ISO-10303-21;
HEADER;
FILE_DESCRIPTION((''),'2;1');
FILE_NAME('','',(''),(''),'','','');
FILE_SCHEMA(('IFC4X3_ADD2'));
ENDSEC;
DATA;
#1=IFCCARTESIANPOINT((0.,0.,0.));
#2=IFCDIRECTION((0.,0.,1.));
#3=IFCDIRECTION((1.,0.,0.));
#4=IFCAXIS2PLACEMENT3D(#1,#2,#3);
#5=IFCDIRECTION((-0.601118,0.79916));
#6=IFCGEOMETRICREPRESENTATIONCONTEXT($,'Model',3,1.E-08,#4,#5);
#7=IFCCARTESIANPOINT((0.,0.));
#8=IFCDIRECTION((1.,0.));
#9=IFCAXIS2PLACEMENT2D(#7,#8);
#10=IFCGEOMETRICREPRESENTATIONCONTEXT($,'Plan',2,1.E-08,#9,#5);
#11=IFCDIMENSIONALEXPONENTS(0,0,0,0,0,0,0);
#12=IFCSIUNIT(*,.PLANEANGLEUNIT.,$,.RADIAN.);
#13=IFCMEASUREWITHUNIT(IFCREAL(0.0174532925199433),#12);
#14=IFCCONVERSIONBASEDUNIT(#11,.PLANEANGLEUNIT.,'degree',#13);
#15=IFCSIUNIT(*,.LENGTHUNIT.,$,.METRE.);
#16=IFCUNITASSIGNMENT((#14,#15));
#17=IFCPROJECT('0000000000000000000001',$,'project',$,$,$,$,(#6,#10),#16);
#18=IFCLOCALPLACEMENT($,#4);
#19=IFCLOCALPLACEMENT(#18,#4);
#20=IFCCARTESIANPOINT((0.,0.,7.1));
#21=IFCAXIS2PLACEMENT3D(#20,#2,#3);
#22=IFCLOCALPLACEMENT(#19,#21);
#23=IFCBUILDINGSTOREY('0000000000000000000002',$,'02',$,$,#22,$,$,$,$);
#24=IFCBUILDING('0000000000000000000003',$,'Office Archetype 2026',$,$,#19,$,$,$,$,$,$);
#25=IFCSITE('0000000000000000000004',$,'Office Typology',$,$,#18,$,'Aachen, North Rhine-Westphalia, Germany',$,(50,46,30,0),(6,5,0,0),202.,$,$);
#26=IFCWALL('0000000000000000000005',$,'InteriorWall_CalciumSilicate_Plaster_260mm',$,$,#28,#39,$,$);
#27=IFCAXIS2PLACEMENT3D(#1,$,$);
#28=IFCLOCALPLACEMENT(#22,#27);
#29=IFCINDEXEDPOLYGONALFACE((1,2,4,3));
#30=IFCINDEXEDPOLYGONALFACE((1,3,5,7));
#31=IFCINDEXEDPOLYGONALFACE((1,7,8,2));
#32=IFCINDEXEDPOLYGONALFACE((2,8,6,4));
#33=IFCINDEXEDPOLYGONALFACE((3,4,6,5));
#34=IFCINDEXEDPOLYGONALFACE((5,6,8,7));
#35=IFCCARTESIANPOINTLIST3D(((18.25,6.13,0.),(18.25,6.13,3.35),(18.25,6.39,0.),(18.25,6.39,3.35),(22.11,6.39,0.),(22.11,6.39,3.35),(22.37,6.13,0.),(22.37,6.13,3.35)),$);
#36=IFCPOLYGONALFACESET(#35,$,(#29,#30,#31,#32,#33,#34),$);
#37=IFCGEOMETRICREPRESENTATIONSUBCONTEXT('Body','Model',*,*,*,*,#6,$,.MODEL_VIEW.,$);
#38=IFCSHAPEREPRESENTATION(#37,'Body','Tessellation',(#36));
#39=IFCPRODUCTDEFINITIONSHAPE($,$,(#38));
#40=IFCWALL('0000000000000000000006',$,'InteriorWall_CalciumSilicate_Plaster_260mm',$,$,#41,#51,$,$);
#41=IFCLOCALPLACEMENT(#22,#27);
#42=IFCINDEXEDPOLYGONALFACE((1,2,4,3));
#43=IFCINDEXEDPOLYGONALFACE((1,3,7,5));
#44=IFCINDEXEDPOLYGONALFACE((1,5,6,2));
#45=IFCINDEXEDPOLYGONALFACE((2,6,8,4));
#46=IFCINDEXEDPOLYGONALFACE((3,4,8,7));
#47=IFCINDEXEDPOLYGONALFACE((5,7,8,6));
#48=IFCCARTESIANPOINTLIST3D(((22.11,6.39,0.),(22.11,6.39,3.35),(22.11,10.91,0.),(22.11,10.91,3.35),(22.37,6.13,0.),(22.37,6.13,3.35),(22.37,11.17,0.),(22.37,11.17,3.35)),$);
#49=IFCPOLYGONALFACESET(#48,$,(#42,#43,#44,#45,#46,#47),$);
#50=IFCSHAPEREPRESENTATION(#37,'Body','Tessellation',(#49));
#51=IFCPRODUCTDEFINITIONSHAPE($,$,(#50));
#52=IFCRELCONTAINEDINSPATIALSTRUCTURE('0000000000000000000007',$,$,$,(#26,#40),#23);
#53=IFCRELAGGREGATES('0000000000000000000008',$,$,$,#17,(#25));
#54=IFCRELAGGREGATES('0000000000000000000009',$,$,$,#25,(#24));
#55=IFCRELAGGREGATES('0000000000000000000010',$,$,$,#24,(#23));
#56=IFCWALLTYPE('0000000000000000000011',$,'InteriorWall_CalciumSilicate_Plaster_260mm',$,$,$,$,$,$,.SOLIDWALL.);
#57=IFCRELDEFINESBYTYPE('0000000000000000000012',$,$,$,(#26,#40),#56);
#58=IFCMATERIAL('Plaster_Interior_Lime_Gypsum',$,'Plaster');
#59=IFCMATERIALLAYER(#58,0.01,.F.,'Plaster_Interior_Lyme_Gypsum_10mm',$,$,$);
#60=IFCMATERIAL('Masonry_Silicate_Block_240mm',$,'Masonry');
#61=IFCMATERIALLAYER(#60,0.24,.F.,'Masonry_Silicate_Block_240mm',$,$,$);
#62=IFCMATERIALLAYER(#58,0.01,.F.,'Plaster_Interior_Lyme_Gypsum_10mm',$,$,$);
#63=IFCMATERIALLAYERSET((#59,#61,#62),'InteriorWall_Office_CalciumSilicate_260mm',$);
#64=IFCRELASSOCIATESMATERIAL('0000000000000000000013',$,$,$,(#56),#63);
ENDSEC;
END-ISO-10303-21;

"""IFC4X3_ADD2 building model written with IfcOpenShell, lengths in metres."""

from ifc_helpers import new_model, entity, si_unit, converted_unit, direction, frame, origin_with_axes, origin_2d_with_axis, place, context, subcontext, project, spatial, line, indexed_curve, outline, extrude, material, layer, layer_set, type_object, element, save


model = new_model("IFC4X3_ADD2")

# Units and contexts
model_context = context("Model", 3, precision=1e-08, world=origin_with_axes(), true_north=direction((-0.601118, 0.79916)))
plan_context = context("Plan", 2, precision=1e-08, world=origin_2d_with_axis(), true_north=direction((-0.601118, 0.79916)))
body_context = subcontext(model_context, "Body", "Model", "MODEL_VIEW")
ifc_project = project(units=[converted_unit("PLANEANGLEUNIT", "degree", entity("IfcReal", 0.0174532925199433), si_unit("PLANEANGLEUNIT", "RADIAN"), dimensions=[0, 0, 0, 0, 0, 0, 0]), si_unit("LENGTHUNIT", "METRE")], contexts=[model_context, plan_context])

# Site, building, storey
site_placement = place(None, origin_with_axes())
site = spatial("IfcSite", under=ifc_project, at=site_placement, Name="Office Typology", LongName="Aachen, North Rhine-Westphalia, Germany", RefLatitude=(50, 46, 30, 0), RefLongitude=(6, 5, 0, 0), RefElevation=202.0)
building_placement = place(site_placement, origin_with_axes())
building = spatial("IfcBuilding", under=site, at=building_placement, Name="Office Archetype 2026")
storey_placement = place(building_placement, frame((0.0, 0.0, 7.1), z_axis=(0.0, 0.0, 1.0), x_axis=(1.0, 0.0, 0.0)))
storey = spatial("IfcBuildingStorey", under=building, at=storey_placement, Name="02")

# Wall
ifc_material_1 = material(Name="Plaster_Interior_Lime_Gypsum", Category="Plaster")
ifc_layer_1 = layer(ifc_material_1, 0.01, ventilated=False, Name="Plaster_Interior_Lyme_Gypsum_10mm")
ifc_material_2 = material(Name="Masonry_Silicate_Block_240mm", Category="Masonry")
ifc_layer_2 = layer(ifc_material_2, 0.24, ventilated=False, Name="Masonry_Silicate_Block_240mm")
ifc_layer_3 = layer(ifc_material_1, 0.01, ventilated=False, Name="Plaster_Interior_Lyme_Gypsum_10mm")
ifc_layer_set_1 = layer_set([ifc_layer_1, ifc_layer_2, ifc_layer_3], Name="InteriorWall_Office_CalciumSilicate_260mm")
wall_type_1 = type_object("IfcWallType", Name="InteriorWall_CalciumSilicate_Plaster_260mm", PredefinedType="SOLIDWALL", material=ifc_layer_set_1)
wall_1_placement = place(storey_placement, frame((18.25, 6.13, 0.0), z_axis=(0.0, 0.0, 1.0), x_axis=(1.0, 0.0, 0.0)))
element("IfcWall", 1, at=wall_1_placement, inside=storey, type_object=wall_type_1, Name="InteriorWall_CalciumSilicate_Plaster_260mm", context=body_context, shape_type="SweptSolid", body=[
    extrude(outline(indexed_curve([(0.0, 0.0), (0.0, 0.26), (3.86, 0.26), (4.12, 0.0)], segments=[line(1, 2, 3, 4, 1)])), origin_with_axes(), (0.0, 0.0, 1.0), 3.35),
])

# Wall
wall_2_placement = place(storey_placement, frame((22.37, 6.13, 0.0), z_axis=(0.0, 0.0, 1.0), x_axis=(0.0, 1.0, 0.0)))
element("IfcWall", 2, at=wall_2_placement, inside=storey, type_object=wall_type_1, Name="InteriorWall_CalciumSilicate_Plaster_260mm", context=body_context, shape_type="SweptSolid", body=[
    extrude(outline(indexed_curve([(0.0, 0.0), (0.26, 0.26), (4.78, 0.26), (5.04, 0.0)], segments=[line(1, 2, 3, 4, 1)])), origin_with_axes(), (0.0, 0.0, 1.0), 3.35),
])

save(model, "model.ifc")
